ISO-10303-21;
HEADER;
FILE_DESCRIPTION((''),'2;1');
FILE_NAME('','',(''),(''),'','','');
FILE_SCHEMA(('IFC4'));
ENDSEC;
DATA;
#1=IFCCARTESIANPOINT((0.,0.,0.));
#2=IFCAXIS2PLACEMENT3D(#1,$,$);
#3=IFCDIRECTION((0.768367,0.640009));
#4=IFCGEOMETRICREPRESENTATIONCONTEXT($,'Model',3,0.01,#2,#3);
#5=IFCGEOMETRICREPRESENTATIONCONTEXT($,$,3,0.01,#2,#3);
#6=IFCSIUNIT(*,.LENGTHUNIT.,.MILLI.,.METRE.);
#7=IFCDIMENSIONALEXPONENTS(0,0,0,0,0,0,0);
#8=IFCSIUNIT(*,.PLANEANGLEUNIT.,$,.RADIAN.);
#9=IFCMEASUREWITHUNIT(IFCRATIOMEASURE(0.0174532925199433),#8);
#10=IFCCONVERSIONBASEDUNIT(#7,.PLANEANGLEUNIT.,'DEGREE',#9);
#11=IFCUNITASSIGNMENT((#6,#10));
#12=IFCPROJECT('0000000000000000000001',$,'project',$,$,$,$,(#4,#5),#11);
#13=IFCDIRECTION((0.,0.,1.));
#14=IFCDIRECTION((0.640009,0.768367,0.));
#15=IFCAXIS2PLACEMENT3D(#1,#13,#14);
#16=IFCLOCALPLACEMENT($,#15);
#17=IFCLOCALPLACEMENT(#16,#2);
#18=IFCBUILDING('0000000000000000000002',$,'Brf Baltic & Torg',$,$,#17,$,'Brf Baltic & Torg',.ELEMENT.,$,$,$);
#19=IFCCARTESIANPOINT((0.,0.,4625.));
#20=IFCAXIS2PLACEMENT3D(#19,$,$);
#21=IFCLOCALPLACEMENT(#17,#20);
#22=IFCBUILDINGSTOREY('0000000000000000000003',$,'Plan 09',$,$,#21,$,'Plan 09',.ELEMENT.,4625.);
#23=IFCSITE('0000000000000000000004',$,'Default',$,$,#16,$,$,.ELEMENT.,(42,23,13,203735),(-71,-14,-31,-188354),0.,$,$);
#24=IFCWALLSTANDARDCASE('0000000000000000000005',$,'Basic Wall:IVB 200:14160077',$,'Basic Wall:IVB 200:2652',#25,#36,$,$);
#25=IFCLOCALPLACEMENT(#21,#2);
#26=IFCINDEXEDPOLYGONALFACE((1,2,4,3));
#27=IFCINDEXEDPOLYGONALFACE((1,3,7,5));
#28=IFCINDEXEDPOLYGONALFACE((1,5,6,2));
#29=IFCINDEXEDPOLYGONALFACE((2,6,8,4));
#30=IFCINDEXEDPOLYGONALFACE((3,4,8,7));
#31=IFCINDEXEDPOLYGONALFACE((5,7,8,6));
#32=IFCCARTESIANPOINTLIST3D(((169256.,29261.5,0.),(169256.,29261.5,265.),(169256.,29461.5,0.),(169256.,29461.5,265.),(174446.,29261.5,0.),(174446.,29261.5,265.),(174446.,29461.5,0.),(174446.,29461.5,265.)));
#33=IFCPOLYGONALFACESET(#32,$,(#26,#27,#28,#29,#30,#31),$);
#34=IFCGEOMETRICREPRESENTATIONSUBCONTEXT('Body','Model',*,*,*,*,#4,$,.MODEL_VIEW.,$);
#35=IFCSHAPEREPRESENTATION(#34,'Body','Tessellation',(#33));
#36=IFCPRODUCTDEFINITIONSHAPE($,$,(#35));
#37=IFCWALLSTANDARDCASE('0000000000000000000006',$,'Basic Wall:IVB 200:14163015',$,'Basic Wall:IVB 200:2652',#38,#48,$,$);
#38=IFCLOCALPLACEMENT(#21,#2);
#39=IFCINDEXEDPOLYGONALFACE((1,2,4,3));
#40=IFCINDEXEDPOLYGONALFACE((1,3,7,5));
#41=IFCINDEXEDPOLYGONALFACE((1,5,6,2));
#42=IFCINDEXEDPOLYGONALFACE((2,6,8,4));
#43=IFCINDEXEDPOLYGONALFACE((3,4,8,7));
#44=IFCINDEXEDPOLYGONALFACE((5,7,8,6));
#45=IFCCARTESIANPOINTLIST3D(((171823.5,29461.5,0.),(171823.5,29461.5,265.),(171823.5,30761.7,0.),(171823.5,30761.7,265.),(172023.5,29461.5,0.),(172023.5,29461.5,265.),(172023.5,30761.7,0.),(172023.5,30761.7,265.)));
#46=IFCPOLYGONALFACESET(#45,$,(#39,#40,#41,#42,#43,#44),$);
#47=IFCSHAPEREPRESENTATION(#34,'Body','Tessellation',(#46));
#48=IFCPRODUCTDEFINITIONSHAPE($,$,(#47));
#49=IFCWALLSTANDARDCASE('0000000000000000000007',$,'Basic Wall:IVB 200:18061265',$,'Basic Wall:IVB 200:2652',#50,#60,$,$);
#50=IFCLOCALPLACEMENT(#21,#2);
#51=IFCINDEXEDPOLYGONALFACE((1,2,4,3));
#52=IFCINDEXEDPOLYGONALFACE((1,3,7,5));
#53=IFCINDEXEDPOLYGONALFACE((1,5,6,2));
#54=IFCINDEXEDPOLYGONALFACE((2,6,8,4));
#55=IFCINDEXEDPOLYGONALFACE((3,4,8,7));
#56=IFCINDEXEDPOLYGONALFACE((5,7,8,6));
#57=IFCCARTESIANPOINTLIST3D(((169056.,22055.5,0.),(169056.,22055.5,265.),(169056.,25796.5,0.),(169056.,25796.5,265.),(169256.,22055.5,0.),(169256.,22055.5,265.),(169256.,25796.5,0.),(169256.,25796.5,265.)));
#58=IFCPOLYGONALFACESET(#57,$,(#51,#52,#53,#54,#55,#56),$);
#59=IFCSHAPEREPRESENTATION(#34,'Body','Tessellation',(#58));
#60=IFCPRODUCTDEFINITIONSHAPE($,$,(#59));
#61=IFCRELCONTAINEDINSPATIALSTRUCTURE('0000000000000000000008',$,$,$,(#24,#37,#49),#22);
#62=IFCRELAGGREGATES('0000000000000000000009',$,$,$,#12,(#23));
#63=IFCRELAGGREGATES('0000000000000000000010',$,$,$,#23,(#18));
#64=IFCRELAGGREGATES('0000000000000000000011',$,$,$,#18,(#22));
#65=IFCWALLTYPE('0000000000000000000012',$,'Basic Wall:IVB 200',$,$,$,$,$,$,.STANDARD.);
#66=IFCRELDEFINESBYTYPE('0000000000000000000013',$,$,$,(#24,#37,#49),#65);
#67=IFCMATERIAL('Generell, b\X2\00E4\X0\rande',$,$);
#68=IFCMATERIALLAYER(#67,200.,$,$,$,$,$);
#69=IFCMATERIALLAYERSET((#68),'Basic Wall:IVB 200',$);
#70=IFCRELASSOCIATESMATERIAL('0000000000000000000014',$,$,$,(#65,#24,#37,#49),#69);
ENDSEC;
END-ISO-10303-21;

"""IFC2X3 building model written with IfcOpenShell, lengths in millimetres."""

from ifc_helpers import new_model, entity, si_unit, converted_unit, direction, frame, frame_2d, origin, place, context, subcontext, project, spatial, rectangle, extrude, clip, halfspace, material, layer, layer_set, layer_usage, type_object, element, save


model = new_model("IFC2X3")

# Units and contexts
model_context = context("Model", 3, precision=0.01, world=origin(), true_north=direction((0.768367, 0.640009)))
context_of_model = context(None, 3, precision=0.01, world=origin(), true_north=direction((0.768367, 0.640009)))
body_context = subcontext(model_context, "Body", "Model", "MODEL_VIEW")
ifc_project = project(units=[si_unit("LENGTHUNIT", "METRE", prefix="MILLI"), converted_unit("PLANEANGLEUNIT", "DEGREE", entity("IfcRatioMeasure", 0.0174532925199433), si_unit("PLANEANGLEUNIT", "RADIAN"), dimensions=[0, 0, 0, 0, 0, 0, 0])], contexts=[model_context, context_of_model])

# Site, building, storey
site_placement = place(None, frame((0.0, 0.0, 0.0), z_axis=(0.0, 0.0, 1.0), x_axis=(0.640009, 0.768367, 0.0)))
site = spatial("IfcSite", under=ifc_project, at=site_placement, Name="Default", CompositionType="ELEMENT", RefLatitude=(42, 23, 13, 203735), RefLongitude=(-71, -14, -31, -188354), RefElevation=0.0)
building_placement = place(site_placement, origin())
building = spatial("IfcBuilding", under=site, at=building_placement, Name="Brf Baltic & Torg", LongName="Brf Baltic & Torg", CompositionType="ELEMENT")
storey_placement = place(building_placement, frame((0.0, 0.0, 4625.0)))
storey = spatial("IfcBuildingStorey", under=building, at=storey_placement, Name="Plan 09", LongName="Plan 09", CompositionType="ELEMENT", Elevation=4625.0)

# Shared definitions
ifc_material_1 = material(Name="Generell, bärande")
ifc_layer = layer(ifc_material_1, 200.0)
ifc_layer_set = layer_set([ifc_layer], Name="Basic Wall:IVB 200")
wall_type = type_object("IfcWallType", Name="Basic Wall:IVB 200", PredefinedType="STANDARD", material=ifc_layer_set)

# Walls
ifc_layer_usage_1 = layer_usage(ifc_layer_set, "AXIS2", "POSITIVE", -100.0)
wall_1_placement = place(storey_placement, frame((169256.0, 29361.5, 0.0)))
element("IfcWallStandardCase", 1, at=wall_1_placement, inside=storey, type_object=wall_type, material=ifc_layer_usage_1, Name="Basic Wall:IVB 200:14160077", ObjectType="Basic Wall:IVB 200:2652", context=body_context, shape_type="Clipping", body=[
    clip(extrude(rectangle(XDim=5190.0, YDim=200.0, at=frame_2d((2595.0, 0.0), x_axis=(-1.0, 0.0))), origin(), (0.0, 0.0, 1.0), 265.0), halfspace(origin(), True)),
])
ifc_layer_usage_2 = layer_usage(ifc_layer_set, "AXIS2", "NEGATIVE", 100.0)
wall_2_placement = place(storey_placement, frame((171923.5, 30761.7, 0.0), z_axis=(0.0, 0.0, 1.0), x_axis=(0.0, -1.0, 0.0)))
element("IfcWallStandardCase", 2, at=wall_2_placement, inside=storey, type_object=wall_type, material=ifc_layer_usage_2, Name="Basic Wall:IVB 200:14163015", ObjectType="Basic Wall:IVB 200:2652", context=body_context, shape_type="Clipping", body=[
    clip(extrude(rectangle(XDim=1300.2, YDim=200.0, at=frame_2d((650.1, 0.0), x_axis=(-1.0, 0.0))), origin(), (0.0, 0.0, 1.0), 265.0), halfspace(origin(), True)),
])
ifc_layer_usage_3 = layer_usage(ifc_layer_set, "AXIS2", "POSITIVE", -100.0)
wall_3_placement = place(storey_placement, frame((169156.0, 25796.5, 0.0), z_axis=(0.0, 0.0, 1.0), x_axis=(0.0, -1.0, 0.0)))
element("IfcWallStandardCase", 3, at=wall_3_placement, inside=storey, type_object=wall_type, material=ifc_layer_usage_3, Name="Basic Wall:IVB 200:18061265", ObjectType="Basic Wall:IVB 200:2652", context=body_context, shape_type="Clipping", body=[
    clip(extrude(rectangle(XDim=3741.0, YDim=200.0, at=frame_2d((1870.5, 0.0), x_axis=(-1.0, 0.0))), origin(), (0.0, 0.0, 1.0), 265.0), halfspace(origin(), True)),
])

save(model, "model.ifc")
